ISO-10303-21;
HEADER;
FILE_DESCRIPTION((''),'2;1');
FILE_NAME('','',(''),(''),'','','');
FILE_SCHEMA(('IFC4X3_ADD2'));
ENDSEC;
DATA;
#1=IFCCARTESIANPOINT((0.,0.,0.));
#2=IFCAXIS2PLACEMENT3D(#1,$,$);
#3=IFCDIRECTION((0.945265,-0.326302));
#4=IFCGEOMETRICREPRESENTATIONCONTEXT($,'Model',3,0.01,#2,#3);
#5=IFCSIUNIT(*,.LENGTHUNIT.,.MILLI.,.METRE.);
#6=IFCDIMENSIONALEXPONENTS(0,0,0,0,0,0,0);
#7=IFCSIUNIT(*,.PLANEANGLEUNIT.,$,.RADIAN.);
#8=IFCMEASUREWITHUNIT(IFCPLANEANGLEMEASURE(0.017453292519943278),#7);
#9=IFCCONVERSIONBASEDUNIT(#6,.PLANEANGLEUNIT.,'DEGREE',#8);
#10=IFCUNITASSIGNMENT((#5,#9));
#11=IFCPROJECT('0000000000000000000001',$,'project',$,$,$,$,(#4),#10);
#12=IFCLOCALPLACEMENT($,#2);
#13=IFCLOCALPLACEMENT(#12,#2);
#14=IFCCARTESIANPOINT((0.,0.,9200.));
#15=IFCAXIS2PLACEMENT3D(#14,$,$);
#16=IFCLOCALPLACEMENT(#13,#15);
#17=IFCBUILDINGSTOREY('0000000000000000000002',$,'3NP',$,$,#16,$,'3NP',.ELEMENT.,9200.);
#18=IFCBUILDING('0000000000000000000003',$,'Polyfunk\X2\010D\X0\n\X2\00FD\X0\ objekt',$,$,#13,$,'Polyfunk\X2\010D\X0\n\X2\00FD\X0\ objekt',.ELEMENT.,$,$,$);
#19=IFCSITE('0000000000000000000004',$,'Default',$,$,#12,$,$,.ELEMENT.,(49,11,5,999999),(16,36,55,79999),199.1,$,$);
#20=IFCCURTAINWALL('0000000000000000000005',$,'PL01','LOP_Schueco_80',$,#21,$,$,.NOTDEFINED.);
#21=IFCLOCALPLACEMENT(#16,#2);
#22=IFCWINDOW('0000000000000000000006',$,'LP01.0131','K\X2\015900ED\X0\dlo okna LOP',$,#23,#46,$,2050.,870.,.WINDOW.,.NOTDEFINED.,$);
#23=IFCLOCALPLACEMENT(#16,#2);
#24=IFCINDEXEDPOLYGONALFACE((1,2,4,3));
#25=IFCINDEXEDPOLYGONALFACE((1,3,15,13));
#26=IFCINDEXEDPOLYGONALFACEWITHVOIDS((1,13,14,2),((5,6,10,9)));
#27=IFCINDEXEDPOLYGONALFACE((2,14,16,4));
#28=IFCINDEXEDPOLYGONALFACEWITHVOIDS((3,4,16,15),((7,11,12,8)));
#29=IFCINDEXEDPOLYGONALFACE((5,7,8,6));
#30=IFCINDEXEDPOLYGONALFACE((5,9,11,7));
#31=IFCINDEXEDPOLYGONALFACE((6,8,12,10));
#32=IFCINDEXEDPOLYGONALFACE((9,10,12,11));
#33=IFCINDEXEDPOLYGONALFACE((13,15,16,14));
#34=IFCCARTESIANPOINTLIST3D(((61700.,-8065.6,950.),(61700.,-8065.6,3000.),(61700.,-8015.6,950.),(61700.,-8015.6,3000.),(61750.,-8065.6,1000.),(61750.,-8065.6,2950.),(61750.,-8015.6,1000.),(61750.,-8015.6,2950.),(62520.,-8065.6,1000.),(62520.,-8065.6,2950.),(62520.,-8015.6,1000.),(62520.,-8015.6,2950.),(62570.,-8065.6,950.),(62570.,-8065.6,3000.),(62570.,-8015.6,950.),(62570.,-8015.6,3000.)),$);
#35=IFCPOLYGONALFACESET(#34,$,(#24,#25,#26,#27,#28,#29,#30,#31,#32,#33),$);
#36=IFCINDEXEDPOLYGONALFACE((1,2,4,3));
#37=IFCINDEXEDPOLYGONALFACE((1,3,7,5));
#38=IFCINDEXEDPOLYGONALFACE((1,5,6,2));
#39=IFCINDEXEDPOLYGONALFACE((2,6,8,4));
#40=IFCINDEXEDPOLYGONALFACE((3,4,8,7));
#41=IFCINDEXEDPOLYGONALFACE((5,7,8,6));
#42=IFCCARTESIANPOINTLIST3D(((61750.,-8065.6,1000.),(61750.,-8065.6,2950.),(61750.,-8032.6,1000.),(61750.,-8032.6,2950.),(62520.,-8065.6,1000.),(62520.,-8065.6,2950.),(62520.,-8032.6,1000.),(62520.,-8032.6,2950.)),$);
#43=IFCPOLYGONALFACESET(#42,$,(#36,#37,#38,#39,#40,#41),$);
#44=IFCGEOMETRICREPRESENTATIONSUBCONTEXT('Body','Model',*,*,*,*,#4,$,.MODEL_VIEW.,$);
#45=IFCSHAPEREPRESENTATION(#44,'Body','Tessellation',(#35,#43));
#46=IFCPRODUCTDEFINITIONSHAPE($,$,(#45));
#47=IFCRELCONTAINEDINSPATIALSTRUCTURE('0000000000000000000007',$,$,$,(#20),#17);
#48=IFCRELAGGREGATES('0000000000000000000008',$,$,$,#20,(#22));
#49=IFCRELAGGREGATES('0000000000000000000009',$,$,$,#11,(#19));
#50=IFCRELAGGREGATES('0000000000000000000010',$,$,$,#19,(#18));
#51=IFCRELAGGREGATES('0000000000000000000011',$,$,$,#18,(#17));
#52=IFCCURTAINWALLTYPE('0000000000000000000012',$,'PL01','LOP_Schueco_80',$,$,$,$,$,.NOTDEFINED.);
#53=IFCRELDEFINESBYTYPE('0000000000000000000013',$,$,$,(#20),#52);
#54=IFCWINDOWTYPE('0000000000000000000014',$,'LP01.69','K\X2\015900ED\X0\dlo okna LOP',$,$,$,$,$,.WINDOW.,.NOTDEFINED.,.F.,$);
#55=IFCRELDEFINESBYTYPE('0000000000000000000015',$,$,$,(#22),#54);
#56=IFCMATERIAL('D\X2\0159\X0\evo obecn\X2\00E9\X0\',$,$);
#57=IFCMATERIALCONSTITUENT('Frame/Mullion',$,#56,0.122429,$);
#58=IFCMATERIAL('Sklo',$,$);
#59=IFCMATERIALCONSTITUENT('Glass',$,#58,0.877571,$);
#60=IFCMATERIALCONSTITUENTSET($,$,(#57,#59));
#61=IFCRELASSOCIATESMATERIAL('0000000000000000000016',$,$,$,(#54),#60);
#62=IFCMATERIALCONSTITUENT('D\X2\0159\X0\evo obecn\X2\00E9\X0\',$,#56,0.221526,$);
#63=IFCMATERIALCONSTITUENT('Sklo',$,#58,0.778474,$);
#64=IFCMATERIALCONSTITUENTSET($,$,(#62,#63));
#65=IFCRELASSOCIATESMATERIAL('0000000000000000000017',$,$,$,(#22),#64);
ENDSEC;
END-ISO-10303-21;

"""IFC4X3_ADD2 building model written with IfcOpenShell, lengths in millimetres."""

from ifc_helpers import new_model, entity, si_unit, converted_unit, direction, frame, frame_2d, origin, place, context, subcontext, project, spatial, polyline, rectangle, outline, extrude, source, transform, mapped, material, constituent, constituent_set, type_object, type_shapes, element, aggregate, save


model = new_model("IFC4X3_ADD2")

# Units and contexts
model_context = context("Model", 3, precision=0.01, world=origin(), true_north=direction((0.945265, -0.326302)))
body_context = subcontext(model_context, "Body", "Model", "MODEL_VIEW")
ifc_project = project(units=[si_unit("LENGTHUNIT", "METRE", prefix="MILLI"), converted_unit("PLANEANGLEUNIT", "DEGREE", entity("IfcPlaneAngleMeasure", 0.017453292519943278), si_unit("PLANEANGLEUNIT", "RADIAN"), dimensions=[0, 0, 0, 0, 0, 0, 0])], contexts=[model_context])

# Site, building, storey
site_placement = place(None, origin())
site = spatial("IfcSite", under=ifc_project, at=site_placement, Name="Default", CompositionType="ELEMENT", RefLatitude=(49, 11, 5, 999999), RefLongitude=(16, 36, 55, 79999), RefElevation=199.1)
building_placement = place(site_placement, origin())
building = spatial("IfcBuilding", under=site, at=building_placement, Name="Polyfunkčný objekt", LongName="Polyfunkčný objekt", CompositionType="ELEMENT")
storey_placement = place(building_placement, frame((0.0, 0.0, 9200.0)))
storey = spatial("IfcBuildingStorey", under=building, at=storey_placement, Name="3NP", LongName="3NP", CompositionType="ELEMENT", Elevation=9200.0)

# Curtain wall
curtain_wall_type = type_object("IfcCurtainWallType", Name="PL01", Description="LOP_Schueco_80", PredefinedType="NOTDEFINED")
curtain_wall_1_placement = place(storey_placement, frame((0.0, 0.0, -9200.0)))
curtain_wall_1 = element("IfcCurtainWall", 1, at=curtain_wall_1_placement, inside=storey, type_object=curtain_wall_type, Name="PL01", Description="LOP_Schueco_80", PredefinedType="NOTDEFINED")

# Shared definitions
ifc_material_1 = material(Name="Sklo")

# Window
ifc_material_2 = material(Name="Dřevo obecné")
ifc_constituent_1 = constituent(ifc_material_2, Name="Dřevo obecné", fraction=0.221526)
ifc_constituent_2 = constituent(ifc_material_1, Name="Sklo", fraction=0.778474)
ifc_constituent_set_1 = constituent_set(constituents=[ifc_constituent_1, ifc_constituent_2])
ifc_constituent_3 = constituent(ifc_material_2, Name="Frame/Mullion", fraction=0.122429)
ifc_constituent_4 = constituent(ifc_material_1, Name="Glass", fraction=0.877571)
ifc_constituent_set_2 = constituent_set(constituents=[ifc_constituent_3, ifc_constituent_4])
window_type_1 = type_object("IfcWindowType", Name="LP01.69", Description="Křídlo okna LOP", ParameterTakesPrecedence=False, PartitioningType="NOTDEFINED", PredefinedType="WINDOW", material=ifc_constituent_set_2)
shared_shape_1 = source(origin(), body_context, "Body", "SweptSolid", [
    extrude(outline(polyline([(-1025.0, -435.0), (1025.0, -435.0), (1025.0, 435.0), (-1025.0, 435.0), (-1025.0, -435.0)]), holes=[polyline([(-975.0, -385.0), (-975.0, 385.0), (975.0, 385.0), (975.0, -385.0), (-975.0, -385.0)])]), frame((0.0, 50.0, 1025.0), z_axis=(0.0, -1.0, 0.0), x_axis=(0.0, 0.0, -1.0)), (0.0, 0.0, 1.0), 50.0),
    extrude(rectangle(XDim=770.0, YDim=33.0, at=frame_2d((0.0, 0.0), x_axis=(1.0, 0.0))), frame((0.0, 33.5, 50.0), z_axis=(0.0, 0.0, 1.0), x_axis=(-1.0, 0.0, 0.0)), (0.0, 0.0, 1.0), 1950.0),
])
type_shapes(window_type_1, [shared_shape_1])
window_1_placement = place(curtain_wall_1_placement, frame((62135.0, -8015.6, 10150.0), z_axis=(0.0, 0.0, 1.0), x_axis=(-1.0, 0.0, 0.0)))
window_1 = element("IfcWindow", 2, at=window_1_placement, type_object=window_type_1, material=ifc_constituent_set_1, Name="LP01.0131", Description="Křídlo okna LOP", OverallHeight=2050.0, OverallWidth=870.0, PartitioningType="NOTDEFINED", PredefinedType="WINDOW", context=body_context, shape_type="MappedRepresentation", body=[
    mapped(shared_shape_1, transform((0.0, 0.0, 0.0), scale=1.0)),
])
aggregate(curtain_wall_1, [window_1])

save(model, "model.ifc")
